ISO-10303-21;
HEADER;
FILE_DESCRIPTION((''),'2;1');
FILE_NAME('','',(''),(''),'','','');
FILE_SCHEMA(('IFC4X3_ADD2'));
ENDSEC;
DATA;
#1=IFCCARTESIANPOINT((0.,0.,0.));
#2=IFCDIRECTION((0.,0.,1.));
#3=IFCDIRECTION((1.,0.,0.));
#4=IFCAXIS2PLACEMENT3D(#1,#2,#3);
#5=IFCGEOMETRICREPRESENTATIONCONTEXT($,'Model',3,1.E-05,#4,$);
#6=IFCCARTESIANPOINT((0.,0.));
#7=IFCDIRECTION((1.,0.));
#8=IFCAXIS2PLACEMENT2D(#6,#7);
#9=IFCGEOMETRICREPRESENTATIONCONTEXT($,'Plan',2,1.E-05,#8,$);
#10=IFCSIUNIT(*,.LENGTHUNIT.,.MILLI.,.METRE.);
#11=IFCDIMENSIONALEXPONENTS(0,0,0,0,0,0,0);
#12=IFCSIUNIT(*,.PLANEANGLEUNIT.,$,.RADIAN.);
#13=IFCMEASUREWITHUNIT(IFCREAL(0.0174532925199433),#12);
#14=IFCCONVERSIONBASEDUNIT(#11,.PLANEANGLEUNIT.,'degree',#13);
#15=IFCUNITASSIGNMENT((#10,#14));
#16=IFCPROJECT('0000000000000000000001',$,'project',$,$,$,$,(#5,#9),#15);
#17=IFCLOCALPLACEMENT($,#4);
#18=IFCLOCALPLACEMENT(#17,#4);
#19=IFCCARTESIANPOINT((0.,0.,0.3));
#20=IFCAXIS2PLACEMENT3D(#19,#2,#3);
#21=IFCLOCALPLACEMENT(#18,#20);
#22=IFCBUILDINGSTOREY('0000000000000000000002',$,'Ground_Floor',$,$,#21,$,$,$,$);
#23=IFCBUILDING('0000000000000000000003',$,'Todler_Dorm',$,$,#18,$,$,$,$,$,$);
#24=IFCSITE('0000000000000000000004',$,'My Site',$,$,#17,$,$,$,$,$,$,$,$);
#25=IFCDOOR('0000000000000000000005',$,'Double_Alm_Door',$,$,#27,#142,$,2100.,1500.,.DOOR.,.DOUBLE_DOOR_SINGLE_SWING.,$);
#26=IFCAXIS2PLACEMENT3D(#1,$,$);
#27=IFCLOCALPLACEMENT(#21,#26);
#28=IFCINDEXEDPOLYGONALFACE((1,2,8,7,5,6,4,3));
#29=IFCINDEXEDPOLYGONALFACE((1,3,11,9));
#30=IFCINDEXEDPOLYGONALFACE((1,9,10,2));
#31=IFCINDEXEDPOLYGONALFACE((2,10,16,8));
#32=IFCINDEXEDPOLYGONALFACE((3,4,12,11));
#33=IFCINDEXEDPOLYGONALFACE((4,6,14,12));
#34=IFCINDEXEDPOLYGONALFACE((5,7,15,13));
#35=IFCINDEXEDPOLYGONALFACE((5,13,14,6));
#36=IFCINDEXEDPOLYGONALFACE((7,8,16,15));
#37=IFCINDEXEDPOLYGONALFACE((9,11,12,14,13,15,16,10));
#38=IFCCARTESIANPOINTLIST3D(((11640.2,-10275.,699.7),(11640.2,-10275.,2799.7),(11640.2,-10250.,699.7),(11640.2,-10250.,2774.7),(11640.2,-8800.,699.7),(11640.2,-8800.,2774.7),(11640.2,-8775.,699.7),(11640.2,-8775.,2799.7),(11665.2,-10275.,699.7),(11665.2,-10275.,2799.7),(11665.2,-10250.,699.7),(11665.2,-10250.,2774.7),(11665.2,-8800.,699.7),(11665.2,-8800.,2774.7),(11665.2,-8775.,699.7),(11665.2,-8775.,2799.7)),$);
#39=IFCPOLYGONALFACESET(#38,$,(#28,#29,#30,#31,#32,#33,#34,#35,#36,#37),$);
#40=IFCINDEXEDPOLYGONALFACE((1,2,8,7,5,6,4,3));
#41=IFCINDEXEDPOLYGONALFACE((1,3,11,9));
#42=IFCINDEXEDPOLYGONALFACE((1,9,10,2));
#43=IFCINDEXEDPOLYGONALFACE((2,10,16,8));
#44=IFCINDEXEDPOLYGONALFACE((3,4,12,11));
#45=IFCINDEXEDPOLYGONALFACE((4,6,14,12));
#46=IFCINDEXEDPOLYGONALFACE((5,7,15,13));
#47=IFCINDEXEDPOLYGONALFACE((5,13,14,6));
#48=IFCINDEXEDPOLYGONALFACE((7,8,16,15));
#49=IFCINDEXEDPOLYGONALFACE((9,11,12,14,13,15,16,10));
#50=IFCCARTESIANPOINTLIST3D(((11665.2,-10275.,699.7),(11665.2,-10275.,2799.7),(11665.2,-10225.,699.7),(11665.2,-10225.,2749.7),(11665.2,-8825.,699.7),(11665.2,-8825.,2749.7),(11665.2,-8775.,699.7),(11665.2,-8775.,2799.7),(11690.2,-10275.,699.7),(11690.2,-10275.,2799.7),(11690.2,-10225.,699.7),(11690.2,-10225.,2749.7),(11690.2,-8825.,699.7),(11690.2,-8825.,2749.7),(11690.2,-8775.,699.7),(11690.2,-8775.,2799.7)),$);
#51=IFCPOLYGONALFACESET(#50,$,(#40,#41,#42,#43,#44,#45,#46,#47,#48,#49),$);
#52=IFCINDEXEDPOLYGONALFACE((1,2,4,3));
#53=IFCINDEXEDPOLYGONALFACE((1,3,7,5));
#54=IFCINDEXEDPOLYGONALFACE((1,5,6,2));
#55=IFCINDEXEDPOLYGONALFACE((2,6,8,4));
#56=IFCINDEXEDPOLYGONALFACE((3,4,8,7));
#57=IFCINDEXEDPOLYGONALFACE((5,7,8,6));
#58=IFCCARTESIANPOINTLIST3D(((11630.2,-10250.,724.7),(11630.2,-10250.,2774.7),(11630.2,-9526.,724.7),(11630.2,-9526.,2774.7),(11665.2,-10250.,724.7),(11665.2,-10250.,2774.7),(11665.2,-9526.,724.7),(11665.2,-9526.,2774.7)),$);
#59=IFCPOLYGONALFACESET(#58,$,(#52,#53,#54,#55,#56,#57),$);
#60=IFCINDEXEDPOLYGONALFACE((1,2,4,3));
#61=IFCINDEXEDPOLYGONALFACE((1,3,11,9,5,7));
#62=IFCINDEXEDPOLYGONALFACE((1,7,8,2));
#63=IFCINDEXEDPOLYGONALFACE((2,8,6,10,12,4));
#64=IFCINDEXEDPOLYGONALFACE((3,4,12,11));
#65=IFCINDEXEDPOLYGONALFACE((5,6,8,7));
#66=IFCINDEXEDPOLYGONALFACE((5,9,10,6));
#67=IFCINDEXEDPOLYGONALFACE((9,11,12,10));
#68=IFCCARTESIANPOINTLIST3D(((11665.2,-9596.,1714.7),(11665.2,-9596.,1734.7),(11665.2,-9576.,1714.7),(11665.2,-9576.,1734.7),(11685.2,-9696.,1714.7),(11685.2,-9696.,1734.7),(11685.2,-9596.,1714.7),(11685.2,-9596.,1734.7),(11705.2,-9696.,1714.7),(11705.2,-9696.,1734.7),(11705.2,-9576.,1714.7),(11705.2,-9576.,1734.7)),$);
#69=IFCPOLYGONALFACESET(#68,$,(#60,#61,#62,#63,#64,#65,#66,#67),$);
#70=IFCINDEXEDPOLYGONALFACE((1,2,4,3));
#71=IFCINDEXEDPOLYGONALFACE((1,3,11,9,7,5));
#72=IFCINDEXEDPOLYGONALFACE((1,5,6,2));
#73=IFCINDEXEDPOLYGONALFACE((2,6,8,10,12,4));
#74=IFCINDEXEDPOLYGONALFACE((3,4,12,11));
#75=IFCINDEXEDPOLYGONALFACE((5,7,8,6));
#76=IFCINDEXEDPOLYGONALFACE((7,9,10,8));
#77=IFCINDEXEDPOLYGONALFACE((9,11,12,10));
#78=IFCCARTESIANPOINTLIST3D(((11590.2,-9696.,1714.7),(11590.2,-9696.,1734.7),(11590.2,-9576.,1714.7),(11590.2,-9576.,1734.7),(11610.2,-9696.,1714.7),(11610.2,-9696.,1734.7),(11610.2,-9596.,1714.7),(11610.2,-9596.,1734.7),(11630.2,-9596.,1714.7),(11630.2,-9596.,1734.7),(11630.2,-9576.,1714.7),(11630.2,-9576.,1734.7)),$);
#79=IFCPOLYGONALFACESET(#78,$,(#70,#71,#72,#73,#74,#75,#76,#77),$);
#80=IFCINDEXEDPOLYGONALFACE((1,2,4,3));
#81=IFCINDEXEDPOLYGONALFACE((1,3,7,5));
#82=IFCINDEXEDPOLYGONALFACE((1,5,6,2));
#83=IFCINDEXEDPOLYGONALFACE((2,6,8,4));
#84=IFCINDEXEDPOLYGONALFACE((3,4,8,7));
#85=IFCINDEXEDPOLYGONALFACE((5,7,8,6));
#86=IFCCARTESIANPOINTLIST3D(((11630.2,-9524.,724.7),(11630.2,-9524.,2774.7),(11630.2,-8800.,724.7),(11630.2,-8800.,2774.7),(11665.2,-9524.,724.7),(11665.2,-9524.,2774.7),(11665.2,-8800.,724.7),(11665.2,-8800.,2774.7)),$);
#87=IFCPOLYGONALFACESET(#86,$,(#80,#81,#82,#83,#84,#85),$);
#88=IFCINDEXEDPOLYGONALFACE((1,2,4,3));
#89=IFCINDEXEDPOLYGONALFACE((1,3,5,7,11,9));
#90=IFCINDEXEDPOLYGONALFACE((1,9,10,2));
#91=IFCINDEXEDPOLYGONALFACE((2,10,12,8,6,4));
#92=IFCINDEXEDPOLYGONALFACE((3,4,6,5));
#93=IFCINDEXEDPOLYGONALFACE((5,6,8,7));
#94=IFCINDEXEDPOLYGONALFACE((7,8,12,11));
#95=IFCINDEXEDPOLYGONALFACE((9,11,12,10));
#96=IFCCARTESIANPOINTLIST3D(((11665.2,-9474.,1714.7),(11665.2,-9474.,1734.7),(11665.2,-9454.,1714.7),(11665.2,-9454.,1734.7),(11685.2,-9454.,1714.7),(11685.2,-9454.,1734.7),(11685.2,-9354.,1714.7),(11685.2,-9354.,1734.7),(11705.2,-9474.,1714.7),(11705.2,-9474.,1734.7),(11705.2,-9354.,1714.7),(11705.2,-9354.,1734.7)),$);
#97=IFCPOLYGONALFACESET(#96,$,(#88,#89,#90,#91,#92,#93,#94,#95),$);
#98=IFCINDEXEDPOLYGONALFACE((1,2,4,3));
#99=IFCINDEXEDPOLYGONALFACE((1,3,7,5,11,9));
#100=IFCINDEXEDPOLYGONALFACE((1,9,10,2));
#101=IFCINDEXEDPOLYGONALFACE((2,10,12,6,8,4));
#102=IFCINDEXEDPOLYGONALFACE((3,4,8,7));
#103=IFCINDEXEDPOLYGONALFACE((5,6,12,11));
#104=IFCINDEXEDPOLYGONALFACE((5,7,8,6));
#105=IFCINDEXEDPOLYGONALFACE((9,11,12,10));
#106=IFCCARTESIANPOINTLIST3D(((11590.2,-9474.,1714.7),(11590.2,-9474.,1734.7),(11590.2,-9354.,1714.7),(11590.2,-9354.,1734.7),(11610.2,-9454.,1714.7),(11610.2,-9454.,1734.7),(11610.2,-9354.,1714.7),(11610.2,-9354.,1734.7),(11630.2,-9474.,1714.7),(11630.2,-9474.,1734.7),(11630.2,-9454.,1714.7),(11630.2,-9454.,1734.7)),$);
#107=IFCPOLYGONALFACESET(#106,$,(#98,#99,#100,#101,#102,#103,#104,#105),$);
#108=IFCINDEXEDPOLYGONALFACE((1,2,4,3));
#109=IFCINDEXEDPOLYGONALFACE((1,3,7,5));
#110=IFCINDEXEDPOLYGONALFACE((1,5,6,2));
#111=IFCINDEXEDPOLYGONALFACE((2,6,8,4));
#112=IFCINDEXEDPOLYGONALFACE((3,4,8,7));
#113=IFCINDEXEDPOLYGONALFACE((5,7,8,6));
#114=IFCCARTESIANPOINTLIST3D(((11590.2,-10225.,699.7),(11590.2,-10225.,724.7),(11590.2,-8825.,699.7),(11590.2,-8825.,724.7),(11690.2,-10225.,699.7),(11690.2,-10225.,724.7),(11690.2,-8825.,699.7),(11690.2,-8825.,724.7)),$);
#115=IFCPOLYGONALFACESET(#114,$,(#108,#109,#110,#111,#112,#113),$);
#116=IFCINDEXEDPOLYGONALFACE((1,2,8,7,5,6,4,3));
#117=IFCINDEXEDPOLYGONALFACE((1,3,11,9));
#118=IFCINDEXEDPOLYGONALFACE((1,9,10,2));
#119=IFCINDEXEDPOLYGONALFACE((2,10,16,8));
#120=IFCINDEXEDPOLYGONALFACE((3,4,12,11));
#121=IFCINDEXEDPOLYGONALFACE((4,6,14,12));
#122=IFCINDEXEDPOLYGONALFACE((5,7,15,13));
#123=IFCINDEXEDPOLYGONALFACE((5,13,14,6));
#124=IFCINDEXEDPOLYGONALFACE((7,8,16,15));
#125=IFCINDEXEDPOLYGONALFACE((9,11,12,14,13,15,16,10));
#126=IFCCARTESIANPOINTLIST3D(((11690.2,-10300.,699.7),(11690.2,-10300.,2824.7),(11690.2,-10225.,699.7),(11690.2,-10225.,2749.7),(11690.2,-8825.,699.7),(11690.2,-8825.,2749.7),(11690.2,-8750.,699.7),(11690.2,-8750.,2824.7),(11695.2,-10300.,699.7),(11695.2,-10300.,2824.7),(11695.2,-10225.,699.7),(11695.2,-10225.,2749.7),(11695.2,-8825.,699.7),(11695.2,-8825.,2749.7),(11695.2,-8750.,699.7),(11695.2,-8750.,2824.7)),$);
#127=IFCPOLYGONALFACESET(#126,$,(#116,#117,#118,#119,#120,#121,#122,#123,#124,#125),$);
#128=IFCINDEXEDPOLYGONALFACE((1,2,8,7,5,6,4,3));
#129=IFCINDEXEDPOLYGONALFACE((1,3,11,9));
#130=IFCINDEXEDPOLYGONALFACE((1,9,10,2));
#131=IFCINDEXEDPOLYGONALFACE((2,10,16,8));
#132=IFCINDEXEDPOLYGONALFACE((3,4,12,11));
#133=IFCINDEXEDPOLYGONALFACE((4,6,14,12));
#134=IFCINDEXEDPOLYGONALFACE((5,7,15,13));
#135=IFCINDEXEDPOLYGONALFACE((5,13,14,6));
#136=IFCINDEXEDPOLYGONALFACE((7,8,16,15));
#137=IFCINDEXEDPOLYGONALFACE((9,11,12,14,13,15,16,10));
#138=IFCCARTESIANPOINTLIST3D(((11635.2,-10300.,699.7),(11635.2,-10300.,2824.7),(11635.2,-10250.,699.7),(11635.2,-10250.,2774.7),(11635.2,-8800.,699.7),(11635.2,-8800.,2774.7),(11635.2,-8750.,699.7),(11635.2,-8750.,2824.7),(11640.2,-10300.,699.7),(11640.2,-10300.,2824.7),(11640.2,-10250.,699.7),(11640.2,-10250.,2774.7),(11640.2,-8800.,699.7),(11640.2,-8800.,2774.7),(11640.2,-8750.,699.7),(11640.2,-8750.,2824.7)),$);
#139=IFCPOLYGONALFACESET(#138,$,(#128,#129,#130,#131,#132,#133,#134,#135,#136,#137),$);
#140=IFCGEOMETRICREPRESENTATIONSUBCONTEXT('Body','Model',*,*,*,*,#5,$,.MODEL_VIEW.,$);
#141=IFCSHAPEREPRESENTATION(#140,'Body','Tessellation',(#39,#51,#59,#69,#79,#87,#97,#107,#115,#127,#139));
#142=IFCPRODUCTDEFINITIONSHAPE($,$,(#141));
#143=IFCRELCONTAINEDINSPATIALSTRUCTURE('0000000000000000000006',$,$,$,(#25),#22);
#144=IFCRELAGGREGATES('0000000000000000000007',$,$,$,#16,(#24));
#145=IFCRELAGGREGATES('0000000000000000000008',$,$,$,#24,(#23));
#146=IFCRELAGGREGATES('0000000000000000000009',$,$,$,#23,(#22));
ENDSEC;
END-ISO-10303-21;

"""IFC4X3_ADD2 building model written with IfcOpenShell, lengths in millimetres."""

from ifc_helpers import new_model, entity, si_unit, converted_unit, frame, origin_with_axes, origin_2d_with_axis, place, context, subcontext, project, spatial, line, indexed_curve, outline, extrude, shape, element, save


model = new_model("IFC4X3_ADD2")

# Units and contexts
model_context = context("Model", 3, precision=1e-05, world=origin_with_axes())
plan_context = context("Plan", 2, precision=1e-05, world=origin_2d_with_axis())
body_context_1 = subcontext(model_context, "Body", "Model", "MODEL_VIEW")
body_context_2 = subcontext(plan_context, "Body", "Plan", "PLAN_VIEW")
ifc_project = project(units=[si_unit("LENGTHUNIT", "METRE", prefix="MILLI"), converted_unit("PLANEANGLEUNIT", "degree", entity("IfcReal", 0.0174532925199433), si_unit("PLANEANGLEUNIT", "RADIAN"), dimensions=[0, 0, 0, 0, 0, 0, 0])], contexts=[model_context, plan_context])

# Site, building, storey
site_placement = place(None, origin_with_axes())
site = spatial("IfcSite", under=ifc_project, at=site_placement, Name="My Site")
building_placement = place(site_placement, origin_with_axes())
building = spatial("IfcBuilding", under=site, at=building_placement, Name="Todler_Dorm")
storey_placement = place(building_placement, frame((0.0, 0.0, 0.3), z_axis=(0.0, 0.0, 1.0), x_axis=(1.0, 0.0, 0.0)))
storey = spatial("IfcBuildingStorey", under=building, at=storey_placement, Name="Ground_Floor")

# Door
door_placement = place(storey_placement, frame((11690.2, -10275.0, 699.7), z_axis=(0.0, 0.0, 1.0), x_axis=(0.0, 1.0, 0.0)))
element("IfcDoor", 1, at=door_placement, inside=storey, Name="Double_Alm_Door", OperationType="DOUBLE_DOOR_SINGLE_SWING", OverallHeight=2100.0, OverallWidth=1500.0, PredefinedType="DOOR", shapes=[
    shape(body_context_1, "Body", "SweptSolid", [extrude(outline(indexed_curve([(0.0, 0.0), (0.0, 2100.0), (1500.0, 2100.0), (1500.0, 0.0), (1475.0, 0.0), (1475.0, 2075.0), (25.0, 2075.0), (25.0, 0.0)], segments=[line(1, 2, 3, 4, 5, 6, 7, 8, 1)])), frame((0.0, 25.0, 0.0), z_axis=(0.0, -1.0, 0.0), x_axis=(1.0, 0.0, 0.0)), (0.0, 0.0, -1.0), 25.0), extrude(outline(indexed_curve([(0.0, 0.0), (0.0, 2100.0), (1500.0, 2100.0), (1500.0, 0.0), (1450.0, 0.0), (1450.0, 2050.0), (50.0, 2050.0), (50.0, 0.0)], segments=[line(1, 2, 3, 4, 5, 6, 7, 8, 1)])), frame((0.0, 0.0, 0.0), z_axis=(0.0, -1.0, 0.0), x_axis=(1.0, 0.0, 0.0)), (0.0, 0.0, -1.0), 25.0), extrude(outline(indexed_curve([(0.0, 0.0), (724.0, 0.0), (724.0, 35.0), (0.0, 35.0)], segments=[line(1, 2, 3, 4, 1)])), frame((25.0, 25.0, 25.0), z_axis=(0.0, 0.0, 1.0), x_axis=(1.0, 0.0, 0.0)), (0.0, 0.0, 1.0), 2050.0), extrude(outline(indexed_curve([(0.0, 0.0), (0.0, -40.0), (-120.0, -40.0), (-120.0, -20.0), (-20.0, -20.0), (-20.0, 0.0)], segments=[line(1, 2, 3, 4, 5, 6, 1)])), frame((699.0, 25.0, 1015.0), z_axis=(0.0, 0.0, 1.0), x_axis=(1.0, 0.0, 0.0)), (0.0, 0.0, 1.0), 20.0), extrude(outline(indexed_curve([(0.0, 0.0), (0.0, 40.0), (-120.0, 40.0), (-120.0, 20.0), (-20.0, 20.0), (-20.0, 0.0)], segments=[line(1, 2, 3, 4, 5, 6, 1)])), frame((699.0, 60.0, 1015.0), z_axis=(0.0, 0.0, 1.0), x_axis=(1.0, 0.0, 0.0)), (0.0, 0.0, 1.0), 20.0), extrude(outline(indexed_curve([(0.0, 0.0), (-724.0, 0.0), (-724.0, 35.0), (0.0, 35.0)], segments=[line(1, 2, 3, 4, 1)])), frame((1475.0, 25.0, 25.0), z_axis=(0.0, 0.0, 1.0), x_axis=(1.0, 0.0, 0.0)), (0.0, 0.0, 1.0), 2050.0), extrude(outline(indexed_curve([(0.0, 0.0), (0.0, -40.0), (120.0, -40.0), (120.0, -20.0), (20.0, -20.0), (20.0, 0.0)], segments=[line(1, 2, 3, 4, 5, 6, 1)])), frame((801.0, 25.0, 1015.0), z_axis=(0.0, 0.0, 1.0), x_axis=(1.0, 0.0, 0.0)), (0.0, 0.0, 1.0), 20.0), extrude(outline(indexed_curve([(0.0, 0.0), (0.0, 40.0), (120.0, 40.0), (120.0, 20.0), (20.0, 20.0), (20.0, 0.0)], segments=[line(1, 2, 3, 4, 5, 6, 1)])), frame((801.0, 60.0, 1015.0), z_axis=(0.0, 0.0, 1.0), x_axis=(1.0, 0.0, 0.0)), (0.0, 0.0, 1.0), 20.0), extrude(outline(indexed_curve([(0.0, 0.0), (1400.0, 0.0), (1400.0, 100.0), (0.0, 100.0)], segments=[line(1, 2, 3, 4, 1)])), frame((50.0, 0.0, 0.0), z_axis=(0.0, 0.0, 1.0), x_axis=(1.0, 0.0, 0.0)), (0.0, 0.0, 1.0), 25.0), extrude(outline(indexed_curve([(0.0, 0.0), (0.0, 2125.0), (1550.0, 2125.0), (1550.0, 0.0), (1475.0, 0.0), (1475.0, 2050.0), (75.0, 2050.0), (75.0, 0.0)], segments=[line(1, 2, 3, 4, 5, 6, 7, 8, 1)])), frame((-25.0, -5.0, 0.0), z_axis=(0.0, -1.0, 0.0), x_axis=(1.0, 0.0, 0.0)), (0.0, 0.0, -1.0), 5.0), extrude(outline(indexed_curve([(0.0, 0.0), (0.0, 2125.0), (1550.0, 2125.0), (1550.0, 0.0), (1500.0, 0.0), (1500.0, 2075.0), (50.0, 2075.0), (50.0, 0.0)], segments=[line(1, 2, 3, 4, 5, 6, 7, 8, 1)])), frame((-25.0, 50.0, 0.0), z_axis=(0.0, -1.0, 0.0), x_axis=(1.0, 0.0, 0.0)), (0.0, 0.0, -1.0), 5.0)]),
    shape(body_context_2, "Body", "Curve2D", [entity("IfcIndexedPolyCurve", entity("IfcCartesianPointList2D", [[0.0, 0.0], [0.0, 50.0], [25.0, 50.0], [25.0, 25.0], [50.0, 25.0], [50.0, 0.0]]), [entity("IfcLineIndex", [1, 2, 3, 4, 5, 6, 1])]), entity("IfcIndexedPolyCurve", entity("IfcCartesianPointList2D", [[1500.0, 0.0], [1500.0, 50.0], [1475.0, 50.0], [1475.0, 25.0], [1450.0, 25.0], [1450.0, 0.0]]), [entity("IfcLineIndex", [1, 2, 3, 4, 5, 6, 1])]), entity("IfcTrimmedCurve", entity("IfcEllipse", entity("IfcAxis2Placement2D", entity("IfcCartesianPoint", [60.0, 50.0]), entity("IfcDirection", [1.0, 0.0])), 690.0, 725.0), [entity("IfcCartesianPoint", [750.0, 50.0])], [entity("IfcCartesianPoint", [60.0, 775.0])], True, "CARTESIAN"), entity("IfcIndexedPolyCurve", entity("IfcCartesianPointList2D", [[25.0, 50.0], [60.0, 50.0], [60.0, 775.0], [25.0, 775.0]]), [entity("IfcLineIndex", [1, 2, 3, 4, 1])]), entity("IfcTrimmedCurve", entity("IfcEllipse", entity("IfcAxis2Placement2D", entity("IfcCartesianPoint", [1440.0, 50.0]), entity("IfcDirection", [1.0, 0.0])), 690.0, 725.0), [entity("IfcCartesianPoint", [1440.0, 775.0])], [entity("IfcCartesianPoint", [750.0, 50.0])], True, "CARTESIAN"), entity("IfcIndexedPolyCurve", entity("IfcCartesianPointList2D", [[1475.0, 50.0], [1440.0, 50.0], [1440.0, 775.0], [1475.0, 775.0]]), [entity("IfcLineIndex", [1, 2, 3, 4, 1])])]),
])

save(model, "model.ifc")
